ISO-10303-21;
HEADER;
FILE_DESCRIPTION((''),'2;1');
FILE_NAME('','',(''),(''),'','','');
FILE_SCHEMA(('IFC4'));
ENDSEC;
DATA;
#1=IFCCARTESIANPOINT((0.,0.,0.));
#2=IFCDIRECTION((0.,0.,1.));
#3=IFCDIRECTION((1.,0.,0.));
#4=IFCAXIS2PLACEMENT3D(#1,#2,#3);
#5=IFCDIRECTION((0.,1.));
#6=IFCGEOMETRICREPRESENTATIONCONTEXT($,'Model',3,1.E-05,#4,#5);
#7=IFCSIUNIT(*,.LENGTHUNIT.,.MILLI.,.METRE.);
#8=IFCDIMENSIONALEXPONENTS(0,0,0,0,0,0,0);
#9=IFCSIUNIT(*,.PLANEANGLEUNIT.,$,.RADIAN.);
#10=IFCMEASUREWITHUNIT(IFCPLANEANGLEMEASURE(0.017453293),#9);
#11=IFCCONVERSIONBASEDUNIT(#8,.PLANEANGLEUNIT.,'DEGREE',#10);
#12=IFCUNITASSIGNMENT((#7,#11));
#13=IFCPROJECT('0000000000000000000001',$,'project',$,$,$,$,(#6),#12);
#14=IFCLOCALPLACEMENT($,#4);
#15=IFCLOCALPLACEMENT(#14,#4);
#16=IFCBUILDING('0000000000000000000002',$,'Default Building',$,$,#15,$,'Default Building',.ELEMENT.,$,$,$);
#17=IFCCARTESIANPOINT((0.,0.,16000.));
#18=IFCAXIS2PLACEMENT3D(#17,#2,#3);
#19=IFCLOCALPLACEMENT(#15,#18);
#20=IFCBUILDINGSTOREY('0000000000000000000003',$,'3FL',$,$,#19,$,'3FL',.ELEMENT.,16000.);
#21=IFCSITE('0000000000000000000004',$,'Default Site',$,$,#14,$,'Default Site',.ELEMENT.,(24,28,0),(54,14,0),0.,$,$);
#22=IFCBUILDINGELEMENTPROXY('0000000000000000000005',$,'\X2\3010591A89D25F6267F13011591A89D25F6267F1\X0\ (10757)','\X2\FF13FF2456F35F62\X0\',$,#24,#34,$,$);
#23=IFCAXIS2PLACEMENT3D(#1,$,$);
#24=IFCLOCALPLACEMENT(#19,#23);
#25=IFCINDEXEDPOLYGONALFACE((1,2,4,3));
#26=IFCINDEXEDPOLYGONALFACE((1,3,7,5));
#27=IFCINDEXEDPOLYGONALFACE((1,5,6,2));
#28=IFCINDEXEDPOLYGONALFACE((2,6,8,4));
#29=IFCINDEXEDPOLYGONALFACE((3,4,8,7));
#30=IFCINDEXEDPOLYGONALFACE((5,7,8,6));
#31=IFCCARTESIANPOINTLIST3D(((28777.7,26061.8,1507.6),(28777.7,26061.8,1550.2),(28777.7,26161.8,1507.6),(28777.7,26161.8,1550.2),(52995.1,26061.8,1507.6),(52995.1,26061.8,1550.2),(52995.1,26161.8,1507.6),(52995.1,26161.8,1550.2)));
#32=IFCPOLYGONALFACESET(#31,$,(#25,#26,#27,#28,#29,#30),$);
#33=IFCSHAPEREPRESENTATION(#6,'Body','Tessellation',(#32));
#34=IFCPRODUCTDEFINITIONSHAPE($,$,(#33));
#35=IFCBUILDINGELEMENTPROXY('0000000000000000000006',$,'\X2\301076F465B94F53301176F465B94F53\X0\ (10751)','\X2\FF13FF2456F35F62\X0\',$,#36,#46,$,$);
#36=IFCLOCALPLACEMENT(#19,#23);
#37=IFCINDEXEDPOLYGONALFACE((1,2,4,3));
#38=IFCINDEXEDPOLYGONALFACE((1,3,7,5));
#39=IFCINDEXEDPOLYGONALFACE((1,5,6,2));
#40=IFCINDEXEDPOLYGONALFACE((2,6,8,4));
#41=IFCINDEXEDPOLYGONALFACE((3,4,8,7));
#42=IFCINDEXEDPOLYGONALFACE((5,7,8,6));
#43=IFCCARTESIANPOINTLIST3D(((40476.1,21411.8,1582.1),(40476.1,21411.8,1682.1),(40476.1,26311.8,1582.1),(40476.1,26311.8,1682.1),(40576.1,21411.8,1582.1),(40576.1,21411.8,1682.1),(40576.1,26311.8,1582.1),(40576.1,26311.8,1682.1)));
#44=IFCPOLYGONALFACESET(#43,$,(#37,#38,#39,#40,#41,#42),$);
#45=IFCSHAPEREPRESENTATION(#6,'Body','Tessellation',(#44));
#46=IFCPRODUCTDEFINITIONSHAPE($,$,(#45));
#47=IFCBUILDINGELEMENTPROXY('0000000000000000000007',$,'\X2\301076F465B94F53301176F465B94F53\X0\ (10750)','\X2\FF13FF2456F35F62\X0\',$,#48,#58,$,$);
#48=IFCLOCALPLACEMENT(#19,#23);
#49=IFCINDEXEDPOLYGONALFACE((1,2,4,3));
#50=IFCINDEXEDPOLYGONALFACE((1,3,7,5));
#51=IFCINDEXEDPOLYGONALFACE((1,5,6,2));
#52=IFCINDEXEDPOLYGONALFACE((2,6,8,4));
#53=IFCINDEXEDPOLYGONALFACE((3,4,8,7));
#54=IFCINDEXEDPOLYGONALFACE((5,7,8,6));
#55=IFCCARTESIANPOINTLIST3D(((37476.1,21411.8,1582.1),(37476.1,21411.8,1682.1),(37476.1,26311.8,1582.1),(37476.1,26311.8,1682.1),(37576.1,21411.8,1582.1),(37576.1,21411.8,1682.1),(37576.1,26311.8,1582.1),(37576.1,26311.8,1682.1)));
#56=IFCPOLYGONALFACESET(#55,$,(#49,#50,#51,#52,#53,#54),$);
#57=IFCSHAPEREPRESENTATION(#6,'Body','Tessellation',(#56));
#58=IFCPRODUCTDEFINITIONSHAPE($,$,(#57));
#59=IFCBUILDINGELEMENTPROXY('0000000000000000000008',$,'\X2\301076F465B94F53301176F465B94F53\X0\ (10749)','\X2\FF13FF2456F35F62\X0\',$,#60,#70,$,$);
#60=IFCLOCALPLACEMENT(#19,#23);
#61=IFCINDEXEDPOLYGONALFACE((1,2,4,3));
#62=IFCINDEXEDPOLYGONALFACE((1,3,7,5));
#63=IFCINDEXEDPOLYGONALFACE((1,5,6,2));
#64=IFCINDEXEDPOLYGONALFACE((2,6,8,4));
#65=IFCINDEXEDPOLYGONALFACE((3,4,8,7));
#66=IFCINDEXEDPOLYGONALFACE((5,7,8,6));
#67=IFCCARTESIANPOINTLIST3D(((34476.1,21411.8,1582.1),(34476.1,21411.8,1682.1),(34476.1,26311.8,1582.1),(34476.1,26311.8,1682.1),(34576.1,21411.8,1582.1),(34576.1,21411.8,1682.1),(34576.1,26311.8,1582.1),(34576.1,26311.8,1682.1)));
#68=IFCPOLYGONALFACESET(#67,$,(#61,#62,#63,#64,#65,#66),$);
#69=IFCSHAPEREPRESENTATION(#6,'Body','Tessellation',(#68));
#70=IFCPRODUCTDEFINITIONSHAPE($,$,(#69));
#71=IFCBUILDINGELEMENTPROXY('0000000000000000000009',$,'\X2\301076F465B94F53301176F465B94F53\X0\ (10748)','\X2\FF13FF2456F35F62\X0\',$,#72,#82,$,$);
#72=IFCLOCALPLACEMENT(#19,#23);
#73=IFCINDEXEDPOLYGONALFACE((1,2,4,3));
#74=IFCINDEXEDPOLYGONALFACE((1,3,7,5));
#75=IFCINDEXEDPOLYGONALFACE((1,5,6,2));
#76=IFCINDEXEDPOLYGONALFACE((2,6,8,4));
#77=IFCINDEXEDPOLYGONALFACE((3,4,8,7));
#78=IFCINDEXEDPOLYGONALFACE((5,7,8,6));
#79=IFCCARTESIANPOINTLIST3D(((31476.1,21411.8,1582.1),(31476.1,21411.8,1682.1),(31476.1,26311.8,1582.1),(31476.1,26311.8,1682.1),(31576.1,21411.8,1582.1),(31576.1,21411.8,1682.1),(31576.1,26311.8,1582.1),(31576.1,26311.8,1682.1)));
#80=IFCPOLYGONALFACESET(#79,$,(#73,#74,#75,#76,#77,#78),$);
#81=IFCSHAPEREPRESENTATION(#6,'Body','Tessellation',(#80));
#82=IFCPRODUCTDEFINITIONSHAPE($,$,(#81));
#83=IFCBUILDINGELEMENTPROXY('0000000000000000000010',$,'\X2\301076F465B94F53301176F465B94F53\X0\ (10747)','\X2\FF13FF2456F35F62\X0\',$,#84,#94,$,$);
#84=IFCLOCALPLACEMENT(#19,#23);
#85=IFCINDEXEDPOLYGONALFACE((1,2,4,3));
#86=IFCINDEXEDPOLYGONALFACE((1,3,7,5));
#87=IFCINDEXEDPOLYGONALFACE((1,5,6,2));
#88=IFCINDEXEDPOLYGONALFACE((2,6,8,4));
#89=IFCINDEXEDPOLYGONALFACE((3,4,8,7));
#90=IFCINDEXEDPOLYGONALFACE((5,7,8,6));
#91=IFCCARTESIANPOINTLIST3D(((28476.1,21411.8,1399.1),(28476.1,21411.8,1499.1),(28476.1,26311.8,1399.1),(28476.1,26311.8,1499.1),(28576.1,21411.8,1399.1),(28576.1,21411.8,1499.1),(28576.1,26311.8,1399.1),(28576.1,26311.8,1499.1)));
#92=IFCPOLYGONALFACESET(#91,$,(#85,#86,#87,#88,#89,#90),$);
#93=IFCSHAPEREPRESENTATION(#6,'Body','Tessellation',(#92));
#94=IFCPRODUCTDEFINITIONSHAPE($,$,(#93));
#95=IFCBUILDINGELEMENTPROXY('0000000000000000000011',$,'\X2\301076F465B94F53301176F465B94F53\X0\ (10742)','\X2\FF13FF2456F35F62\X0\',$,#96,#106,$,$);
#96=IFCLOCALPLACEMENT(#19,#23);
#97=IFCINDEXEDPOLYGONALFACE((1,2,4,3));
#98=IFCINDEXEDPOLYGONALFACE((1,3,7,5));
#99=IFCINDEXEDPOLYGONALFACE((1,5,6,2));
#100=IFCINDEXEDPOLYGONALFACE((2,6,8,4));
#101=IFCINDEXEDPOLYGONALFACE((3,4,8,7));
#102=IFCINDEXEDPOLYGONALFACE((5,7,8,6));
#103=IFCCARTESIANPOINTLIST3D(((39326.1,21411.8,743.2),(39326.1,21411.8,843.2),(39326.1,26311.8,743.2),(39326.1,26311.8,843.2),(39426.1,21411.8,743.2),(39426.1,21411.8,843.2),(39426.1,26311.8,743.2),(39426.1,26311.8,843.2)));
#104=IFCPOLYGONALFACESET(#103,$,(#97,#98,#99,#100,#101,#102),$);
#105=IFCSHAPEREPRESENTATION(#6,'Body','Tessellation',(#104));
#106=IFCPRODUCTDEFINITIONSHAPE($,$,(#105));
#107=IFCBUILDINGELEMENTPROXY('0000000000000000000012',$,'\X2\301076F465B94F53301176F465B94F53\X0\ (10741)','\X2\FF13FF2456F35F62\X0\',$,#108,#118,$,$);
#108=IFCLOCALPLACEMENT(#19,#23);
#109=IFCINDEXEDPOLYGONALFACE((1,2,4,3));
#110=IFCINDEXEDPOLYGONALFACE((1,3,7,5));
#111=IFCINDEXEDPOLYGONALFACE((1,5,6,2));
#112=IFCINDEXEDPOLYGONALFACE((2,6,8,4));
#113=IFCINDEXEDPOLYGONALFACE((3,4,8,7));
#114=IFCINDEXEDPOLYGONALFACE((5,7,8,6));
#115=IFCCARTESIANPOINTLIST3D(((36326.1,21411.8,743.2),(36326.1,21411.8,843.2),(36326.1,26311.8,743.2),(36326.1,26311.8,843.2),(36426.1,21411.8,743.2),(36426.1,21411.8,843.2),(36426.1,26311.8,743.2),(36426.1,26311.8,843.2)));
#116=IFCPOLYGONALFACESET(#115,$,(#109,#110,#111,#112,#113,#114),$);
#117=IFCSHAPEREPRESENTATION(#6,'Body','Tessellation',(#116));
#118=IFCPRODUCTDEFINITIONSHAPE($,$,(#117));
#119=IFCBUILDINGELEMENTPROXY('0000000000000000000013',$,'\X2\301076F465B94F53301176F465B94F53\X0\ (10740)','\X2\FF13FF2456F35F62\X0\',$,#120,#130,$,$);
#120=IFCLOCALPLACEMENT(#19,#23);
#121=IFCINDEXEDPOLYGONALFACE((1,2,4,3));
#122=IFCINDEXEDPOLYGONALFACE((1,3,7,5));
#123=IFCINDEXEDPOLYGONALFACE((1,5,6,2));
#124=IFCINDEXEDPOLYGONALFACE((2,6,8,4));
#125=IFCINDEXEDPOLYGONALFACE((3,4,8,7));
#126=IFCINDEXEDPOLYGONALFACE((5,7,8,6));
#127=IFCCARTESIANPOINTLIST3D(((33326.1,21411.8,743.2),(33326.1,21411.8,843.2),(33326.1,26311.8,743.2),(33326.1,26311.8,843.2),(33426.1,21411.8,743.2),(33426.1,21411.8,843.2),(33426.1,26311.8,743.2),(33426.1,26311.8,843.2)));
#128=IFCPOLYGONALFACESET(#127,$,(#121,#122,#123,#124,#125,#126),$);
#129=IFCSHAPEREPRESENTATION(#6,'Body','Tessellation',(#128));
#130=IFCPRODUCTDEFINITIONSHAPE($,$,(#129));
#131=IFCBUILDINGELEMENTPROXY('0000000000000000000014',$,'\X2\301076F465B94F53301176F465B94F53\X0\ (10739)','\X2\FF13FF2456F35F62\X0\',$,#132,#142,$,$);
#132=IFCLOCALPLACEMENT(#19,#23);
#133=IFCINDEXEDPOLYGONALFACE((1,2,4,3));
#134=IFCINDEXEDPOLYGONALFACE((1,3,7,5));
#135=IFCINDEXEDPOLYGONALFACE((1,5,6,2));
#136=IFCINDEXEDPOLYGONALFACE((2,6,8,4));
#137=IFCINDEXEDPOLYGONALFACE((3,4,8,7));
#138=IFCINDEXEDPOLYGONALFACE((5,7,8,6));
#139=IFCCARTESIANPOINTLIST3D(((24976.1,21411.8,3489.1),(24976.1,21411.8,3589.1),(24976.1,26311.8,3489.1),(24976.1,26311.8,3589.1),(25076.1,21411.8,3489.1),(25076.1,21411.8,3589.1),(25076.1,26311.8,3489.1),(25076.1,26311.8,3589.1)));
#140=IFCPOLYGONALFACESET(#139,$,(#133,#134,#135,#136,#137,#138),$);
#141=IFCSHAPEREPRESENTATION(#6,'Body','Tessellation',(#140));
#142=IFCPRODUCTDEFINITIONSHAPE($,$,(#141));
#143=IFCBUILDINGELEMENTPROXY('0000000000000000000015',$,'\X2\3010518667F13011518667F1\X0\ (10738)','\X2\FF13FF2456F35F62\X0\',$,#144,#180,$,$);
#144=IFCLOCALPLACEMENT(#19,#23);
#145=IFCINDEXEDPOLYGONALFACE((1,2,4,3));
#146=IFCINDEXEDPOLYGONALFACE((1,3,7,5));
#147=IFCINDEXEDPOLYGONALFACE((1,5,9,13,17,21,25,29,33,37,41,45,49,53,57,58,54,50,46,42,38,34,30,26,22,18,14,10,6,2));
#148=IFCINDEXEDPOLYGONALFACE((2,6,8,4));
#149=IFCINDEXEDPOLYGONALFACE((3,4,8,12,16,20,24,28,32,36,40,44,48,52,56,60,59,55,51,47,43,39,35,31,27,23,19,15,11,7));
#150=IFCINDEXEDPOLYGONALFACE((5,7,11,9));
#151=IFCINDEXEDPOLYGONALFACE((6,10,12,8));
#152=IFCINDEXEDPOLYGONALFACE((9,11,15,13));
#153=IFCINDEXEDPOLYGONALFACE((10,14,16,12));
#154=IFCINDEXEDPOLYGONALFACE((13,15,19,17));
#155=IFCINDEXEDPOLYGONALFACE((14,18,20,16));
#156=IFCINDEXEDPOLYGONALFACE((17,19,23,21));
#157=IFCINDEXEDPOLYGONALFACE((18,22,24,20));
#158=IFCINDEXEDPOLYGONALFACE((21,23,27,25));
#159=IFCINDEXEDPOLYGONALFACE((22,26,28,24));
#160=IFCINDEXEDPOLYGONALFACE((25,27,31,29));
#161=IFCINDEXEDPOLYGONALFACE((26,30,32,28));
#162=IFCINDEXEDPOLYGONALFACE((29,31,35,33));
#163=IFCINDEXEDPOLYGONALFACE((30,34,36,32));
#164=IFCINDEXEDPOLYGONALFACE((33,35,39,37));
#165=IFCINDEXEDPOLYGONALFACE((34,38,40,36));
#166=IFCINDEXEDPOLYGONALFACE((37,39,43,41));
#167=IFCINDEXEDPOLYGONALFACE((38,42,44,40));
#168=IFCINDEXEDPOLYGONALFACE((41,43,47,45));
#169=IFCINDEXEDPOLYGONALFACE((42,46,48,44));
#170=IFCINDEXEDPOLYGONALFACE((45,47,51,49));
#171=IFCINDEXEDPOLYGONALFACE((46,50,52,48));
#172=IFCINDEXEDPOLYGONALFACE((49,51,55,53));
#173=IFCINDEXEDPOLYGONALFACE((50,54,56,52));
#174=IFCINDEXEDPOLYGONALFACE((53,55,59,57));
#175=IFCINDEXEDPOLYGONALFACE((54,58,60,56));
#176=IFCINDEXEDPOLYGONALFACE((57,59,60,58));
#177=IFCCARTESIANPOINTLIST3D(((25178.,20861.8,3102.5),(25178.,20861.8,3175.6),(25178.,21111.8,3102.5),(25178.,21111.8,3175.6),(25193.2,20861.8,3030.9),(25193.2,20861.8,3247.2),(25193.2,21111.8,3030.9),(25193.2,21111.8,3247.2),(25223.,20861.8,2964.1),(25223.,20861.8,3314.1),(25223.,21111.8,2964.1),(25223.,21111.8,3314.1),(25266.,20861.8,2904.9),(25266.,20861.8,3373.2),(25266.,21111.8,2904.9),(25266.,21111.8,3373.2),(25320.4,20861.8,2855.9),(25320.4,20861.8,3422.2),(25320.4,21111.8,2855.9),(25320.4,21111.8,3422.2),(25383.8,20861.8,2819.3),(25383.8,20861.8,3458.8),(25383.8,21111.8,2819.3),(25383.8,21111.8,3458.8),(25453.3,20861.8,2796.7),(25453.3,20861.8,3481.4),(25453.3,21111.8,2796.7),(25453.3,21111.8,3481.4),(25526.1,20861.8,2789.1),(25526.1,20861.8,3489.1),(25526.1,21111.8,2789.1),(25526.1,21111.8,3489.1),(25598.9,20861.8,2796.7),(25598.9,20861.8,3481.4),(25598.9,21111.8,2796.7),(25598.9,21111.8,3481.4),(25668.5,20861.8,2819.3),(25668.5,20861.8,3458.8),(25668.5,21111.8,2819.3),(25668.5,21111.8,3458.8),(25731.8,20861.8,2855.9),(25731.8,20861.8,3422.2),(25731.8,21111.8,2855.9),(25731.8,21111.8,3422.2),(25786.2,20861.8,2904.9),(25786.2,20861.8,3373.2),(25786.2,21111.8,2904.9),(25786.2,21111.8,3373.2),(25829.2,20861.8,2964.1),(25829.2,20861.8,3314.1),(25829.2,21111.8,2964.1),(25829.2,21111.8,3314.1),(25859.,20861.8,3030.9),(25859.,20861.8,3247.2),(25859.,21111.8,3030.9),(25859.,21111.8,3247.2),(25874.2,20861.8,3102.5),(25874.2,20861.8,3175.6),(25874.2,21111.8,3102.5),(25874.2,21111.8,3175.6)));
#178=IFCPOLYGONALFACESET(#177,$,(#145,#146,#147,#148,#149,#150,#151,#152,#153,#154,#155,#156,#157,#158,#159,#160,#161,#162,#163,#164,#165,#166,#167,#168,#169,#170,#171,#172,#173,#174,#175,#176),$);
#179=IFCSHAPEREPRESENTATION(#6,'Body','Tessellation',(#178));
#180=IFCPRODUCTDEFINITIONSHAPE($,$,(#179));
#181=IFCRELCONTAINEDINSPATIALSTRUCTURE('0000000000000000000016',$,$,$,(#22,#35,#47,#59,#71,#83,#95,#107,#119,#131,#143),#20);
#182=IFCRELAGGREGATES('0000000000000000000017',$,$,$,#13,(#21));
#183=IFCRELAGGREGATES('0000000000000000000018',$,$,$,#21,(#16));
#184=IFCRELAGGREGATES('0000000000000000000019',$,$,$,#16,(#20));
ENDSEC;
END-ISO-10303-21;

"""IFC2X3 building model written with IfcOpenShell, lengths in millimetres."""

from ifc_helpers import new_model, entity, si_unit, converted_unit, direction, frame, origin_with_axes, origin_2d_with_axis, place, context, project, spatial, polyline, rectangle, circle, outline, extrude, source, transform, mapped, element, save


model = new_model("IFC2X3")

# Units and contexts
model_context = context("Model", 3, precision=1e-05, world=origin_with_axes(), true_north=direction((0.0, 1.0)))
ifc_project = project(units=[si_unit("LENGTHUNIT", "METRE", prefix="MILLI"), converted_unit("PLANEANGLEUNIT", "DEGREE", entity("IfcPlaneAngleMeasure", 0.017453293), si_unit("PLANEANGLEUNIT", "RADIAN"), dimensions=[0, 0, 0, 0, 0, 0, 0])], contexts=[model_context])

# Site, building, storey
site_placement = place(None, origin_with_axes())
site = spatial("IfcSite", under=ifc_project, at=site_placement, Name="Default Site", LongName="Default Site", CompositionType="ELEMENT", RefLatitude=(24, 28, 0), RefLongitude=(54, 14, 0), RefElevation=0.0)
building_placement = place(site_placement, origin_with_axes())
building = spatial("IfcBuilding", under=site, at=building_placement, Name="Default Building", LongName="Default Building", CompositionType="ELEMENT")
storey_placement = place(building_placement, frame((0.0, 0.0, 16000.0), z_axis=(0.0, 0.0, 1.0), x_axis=(1.0, 0.0, 0.0)))
storey = spatial("IfcBuildingStorey", under=building, at=storey_placement, Name="3FL", LongName="3FL", CompositionType="ELEMENT", Elevation=16000.0)

# Building element proxies
shared_shape_1 = source(origin_with_axes(), model_context, "Body", "SweptSolid", [
    extrude(outline(polyline([(-12108.7, -21.3), (12108.7, -21.3), (12108.7, 21.3), (-12108.7, 21.3), (-12108.7, -21.3)])), origin_with_axes(), (0.0, 0.0, 1.0), 100.0),
])
proxy_1_placement = place(storey_placement, frame((40886.4, 26161.8, 1528.9), z_axis=(0.0, -1.0, 0.0), x_axis=(1.0, 0.0, 0.0)))
element("IfcBuildingElementProxy", 1, at=proxy_1_placement, inside=storey, Name="【多角形柱】多角形柱 (10757)", Description="３Ｄ図形", context=model_context, shape_type="MappedRepresentation", body=[
    mapped(shared_shape_1, transform((0.0, 0.0, 0.0))),
])
shared_shape_2 = source(origin_with_axes(), model_context, "Body", "SweptSolid", [
    extrude(rectangle(XDim=100.0, YDim=4900.0, at=origin_2d_with_axis()), origin_with_axes(), (0.0, 0.0, 1.0), 100.0),
])
proxy_2_placement = place(storey_placement, frame((40526.1, 23861.8, 1582.1), z_axis=(0.0, 0.0, 1.0), x_axis=(1.0, 0.0, 0.0)))
element("IfcBuildingElementProxy", 2, at=proxy_2_placement, inside=storey, Name="【直方体】直方体 (10751)", Description="３Ｄ図形", context=model_context, shape_type="MappedRepresentation", body=[
    mapped(shared_shape_2, transform((0.0, 0.0, 0.0))),
])
shared_shape_3 = source(origin_with_axes(), model_context, "Body", "SweptSolid", [
    extrude(rectangle(XDim=100.0, YDim=4900.0, at=origin_2d_with_axis()), origin_with_axes(), (0.0, 0.0, 1.0), 100.0),
])
proxy_3_placement = place(storey_placement, frame((37526.1, 23861.8, 1582.1), z_axis=(0.0, 0.0, 1.0), x_axis=(1.0, 0.0, 0.0)))
element("IfcBuildingElementProxy", 3, at=proxy_3_placement, inside=storey, Name="【直方体】直方体 (10750)", Description="３Ｄ図形", context=model_context, shape_type="MappedRepresentation", body=[
    mapped(shared_shape_3, transform((0.0, 0.0, 0.0))),
])
shared_shape_4 = source(origin_with_axes(), model_context, "Body", "SweptSolid", [
    extrude(rectangle(XDim=100.0, YDim=4900.0, at=origin_2d_with_axis()), origin_with_axes(), (0.0, 0.0, 1.0), 100.0),
])
proxy_4_placement = place(storey_placement, frame((34526.1, 23861.8, 1582.1), z_axis=(0.0, 0.0, 1.0), x_axis=(1.0, 0.0, 0.0)))
element("IfcBuildingElementProxy", 4, at=proxy_4_placement, inside=storey, Name="【直方体】直方体 (10749)", Description="３Ｄ図形", context=model_context, shape_type="MappedRepresentation", body=[
    mapped(shared_shape_4, transform((0.0, 0.0, 0.0))),
])
shared_shape_5 = source(origin_with_axes(), model_context, "Body", "SweptSolid", [
    extrude(rectangle(XDim=100.0, YDim=4900.0, at=origin_2d_with_axis()), origin_with_axes(), (0.0, 0.0, 1.0), 100.0),
])
proxy_5_placement = place(storey_placement, frame((31526.1, 23861.8, 1582.1), z_axis=(0.0, 0.0, 1.0), x_axis=(1.0, 0.0, 0.0)))
element("IfcBuildingElementProxy", 5, at=proxy_5_placement, inside=storey, Name="【直方体】直方体 (10748)", Description="３Ｄ図形", context=model_context, shape_type="MappedRepresentation", body=[
    mapped(shared_shape_5, transform((0.0, 0.0, 0.0))),
])
shared_shape_6 = source(origin_with_axes(), model_context, "Body", "SweptSolid", [
    extrude(rectangle(XDim=100.0, YDim=4900.0, at=origin_2d_with_axis()), origin_with_axes(), (0.0, 0.0, 1.0), 100.0),
])
proxy_6_placement = place(storey_placement, frame((28526.1, 23861.8, 1399.1), z_axis=(0.0, 0.0, 1.0), x_axis=(1.0, 0.0, 0.0)))
element("IfcBuildingElementProxy", 6, at=proxy_6_placement, inside=storey, Name="【直方体】直方体 (10747)", Description="３Ｄ図形", context=model_context, shape_type="MappedRepresentation", body=[
    mapped(shared_shape_6, transform((0.0, 0.0, 0.0))),
])
shared_shape_7 = source(origin_with_axes(), model_context, "Body", "SweptSolid", [
    extrude(rectangle(XDim=100.0, YDim=4900.0, at=origin_2d_with_axis()), origin_with_axes(), (0.0, 0.0, 1.0), 100.0),
])
proxy_7_placement = place(storey_placement, frame((39376.1, 23861.8, 743.2), z_axis=(0.0, 0.0, 1.0), x_axis=(1.0, 0.0, 0.0)))
element("IfcBuildingElementProxy", 7, at=proxy_7_placement, inside=storey, Name="【直方体】直方体 (10742)", Description="３Ｄ図形", context=model_context, shape_type="MappedRepresentation", body=[
    mapped(shared_shape_7, transform((0.0, 0.0, 0.0))),
])
shared_shape_8 = source(origin_with_axes(), model_context, "Body", "SweptSolid", [
    extrude(rectangle(XDim=100.0, YDim=4900.0, at=origin_2d_with_axis()), origin_with_axes(), (0.0, 0.0, 1.0), 100.0),
])
proxy_8_placement = place(storey_placement, frame((36376.1, 23861.8, 743.2), z_axis=(0.0, 0.0, 1.0), x_axis=(1.0, 0.0, 0.0)))
element("IfcBuildingElementProxy", 8, at=proxy_8_placement, inside=storey, Name="【直方体】直方体 (10741)", Description="３Ｄ図形", context=model_context, shape_type="MappedRepresentation", body=[
    mapped(shared_shape_8, transform((0.0, 0.0, 0.0))),
])
shared_shape_9 = source(origin_with_axes(), model_context, "Body", "SweptSolid", [
    extrude(rectangle(XDim=100.0, YDim=4900.0, at=origin_2d_with_axis()), origin_with_axes(), (0.0, 0.0, 1.0), 100.0),
])
proxy_9_placement = place(storey_placement, frame((33376.1, 23861.8, 743.2), z_axis=(0.0, 0.0, 1.0), x_axis=(1.0, 0.0, 0.0)))
element("IfcBuildingElementProxy", 9, at=proxy_9_placement, inside=storey, Name="【直方体】直方体 (10740)", Description="３Ｄ図形", context=model_context, shape_type="MappedRepresentation", body=[
    mapped(shared_shape_9, transform((0.0, 0.0, 0.0))),
])
shared_shape_10 = source(origin_with_axes(), model_context, "Body", "SweptSolid", [
    extrude(rectangle(XDim=100.0, YDim=4900.0, at=origin_2d_with_axis()), origin_with_axes(), (0.0, 0.0, 1.0), 100.0),
])
proxy_10_placement = place(storey_placement, frame((25026.1, 23861.8, 3489.1), z_axis=(0.0, 0.0, 1.0), x_axis=(1.0, 0.0, 0.0)))
element("IfcBuildingElementProxy", 10, at=proxy_10_placement, inside=storey, Name="【直方体】直方体 (10739)", Description="３Ｄ図形", context=model_context, shape_type="MappedRepresentation", body=[
    mapped(shared_shape_10, transform((0.0, 0.0, 0.0))),
])
shared_shape_11 = source(origin_with_axes(), model_context, "Body", "SweptSolid", [
    extrude(circle(Radius=350.0, at=origin_2d_with_axis()), frame((0.0, 0.0, 0.0), z_axis=(0.0, 0.0, 1.0), x_axis=(1.0, 0.0, 0.0)), (0.0, 0.0, 1.0), 250.0),
])
proxy_11_placement = place(storey_placement, frame((25526.1, 20861.8, 3139.1), z_axis=(0.0, 1.0, 0.0), x_axis=(0.0, 0.0, -1.0)))
element("IfcBuildingElementProxy", 11, at=proxy_11_placement, inside=storey, Name="【円柱】円柱 (10738)", Description="３Ｄ図形", context=model_context, shape_type="MappedRepresentation", body=[
    mapped(shared_shape_11, transform((0.0, 0.0, 0.0))),
])

save(model, "model.ifc")
